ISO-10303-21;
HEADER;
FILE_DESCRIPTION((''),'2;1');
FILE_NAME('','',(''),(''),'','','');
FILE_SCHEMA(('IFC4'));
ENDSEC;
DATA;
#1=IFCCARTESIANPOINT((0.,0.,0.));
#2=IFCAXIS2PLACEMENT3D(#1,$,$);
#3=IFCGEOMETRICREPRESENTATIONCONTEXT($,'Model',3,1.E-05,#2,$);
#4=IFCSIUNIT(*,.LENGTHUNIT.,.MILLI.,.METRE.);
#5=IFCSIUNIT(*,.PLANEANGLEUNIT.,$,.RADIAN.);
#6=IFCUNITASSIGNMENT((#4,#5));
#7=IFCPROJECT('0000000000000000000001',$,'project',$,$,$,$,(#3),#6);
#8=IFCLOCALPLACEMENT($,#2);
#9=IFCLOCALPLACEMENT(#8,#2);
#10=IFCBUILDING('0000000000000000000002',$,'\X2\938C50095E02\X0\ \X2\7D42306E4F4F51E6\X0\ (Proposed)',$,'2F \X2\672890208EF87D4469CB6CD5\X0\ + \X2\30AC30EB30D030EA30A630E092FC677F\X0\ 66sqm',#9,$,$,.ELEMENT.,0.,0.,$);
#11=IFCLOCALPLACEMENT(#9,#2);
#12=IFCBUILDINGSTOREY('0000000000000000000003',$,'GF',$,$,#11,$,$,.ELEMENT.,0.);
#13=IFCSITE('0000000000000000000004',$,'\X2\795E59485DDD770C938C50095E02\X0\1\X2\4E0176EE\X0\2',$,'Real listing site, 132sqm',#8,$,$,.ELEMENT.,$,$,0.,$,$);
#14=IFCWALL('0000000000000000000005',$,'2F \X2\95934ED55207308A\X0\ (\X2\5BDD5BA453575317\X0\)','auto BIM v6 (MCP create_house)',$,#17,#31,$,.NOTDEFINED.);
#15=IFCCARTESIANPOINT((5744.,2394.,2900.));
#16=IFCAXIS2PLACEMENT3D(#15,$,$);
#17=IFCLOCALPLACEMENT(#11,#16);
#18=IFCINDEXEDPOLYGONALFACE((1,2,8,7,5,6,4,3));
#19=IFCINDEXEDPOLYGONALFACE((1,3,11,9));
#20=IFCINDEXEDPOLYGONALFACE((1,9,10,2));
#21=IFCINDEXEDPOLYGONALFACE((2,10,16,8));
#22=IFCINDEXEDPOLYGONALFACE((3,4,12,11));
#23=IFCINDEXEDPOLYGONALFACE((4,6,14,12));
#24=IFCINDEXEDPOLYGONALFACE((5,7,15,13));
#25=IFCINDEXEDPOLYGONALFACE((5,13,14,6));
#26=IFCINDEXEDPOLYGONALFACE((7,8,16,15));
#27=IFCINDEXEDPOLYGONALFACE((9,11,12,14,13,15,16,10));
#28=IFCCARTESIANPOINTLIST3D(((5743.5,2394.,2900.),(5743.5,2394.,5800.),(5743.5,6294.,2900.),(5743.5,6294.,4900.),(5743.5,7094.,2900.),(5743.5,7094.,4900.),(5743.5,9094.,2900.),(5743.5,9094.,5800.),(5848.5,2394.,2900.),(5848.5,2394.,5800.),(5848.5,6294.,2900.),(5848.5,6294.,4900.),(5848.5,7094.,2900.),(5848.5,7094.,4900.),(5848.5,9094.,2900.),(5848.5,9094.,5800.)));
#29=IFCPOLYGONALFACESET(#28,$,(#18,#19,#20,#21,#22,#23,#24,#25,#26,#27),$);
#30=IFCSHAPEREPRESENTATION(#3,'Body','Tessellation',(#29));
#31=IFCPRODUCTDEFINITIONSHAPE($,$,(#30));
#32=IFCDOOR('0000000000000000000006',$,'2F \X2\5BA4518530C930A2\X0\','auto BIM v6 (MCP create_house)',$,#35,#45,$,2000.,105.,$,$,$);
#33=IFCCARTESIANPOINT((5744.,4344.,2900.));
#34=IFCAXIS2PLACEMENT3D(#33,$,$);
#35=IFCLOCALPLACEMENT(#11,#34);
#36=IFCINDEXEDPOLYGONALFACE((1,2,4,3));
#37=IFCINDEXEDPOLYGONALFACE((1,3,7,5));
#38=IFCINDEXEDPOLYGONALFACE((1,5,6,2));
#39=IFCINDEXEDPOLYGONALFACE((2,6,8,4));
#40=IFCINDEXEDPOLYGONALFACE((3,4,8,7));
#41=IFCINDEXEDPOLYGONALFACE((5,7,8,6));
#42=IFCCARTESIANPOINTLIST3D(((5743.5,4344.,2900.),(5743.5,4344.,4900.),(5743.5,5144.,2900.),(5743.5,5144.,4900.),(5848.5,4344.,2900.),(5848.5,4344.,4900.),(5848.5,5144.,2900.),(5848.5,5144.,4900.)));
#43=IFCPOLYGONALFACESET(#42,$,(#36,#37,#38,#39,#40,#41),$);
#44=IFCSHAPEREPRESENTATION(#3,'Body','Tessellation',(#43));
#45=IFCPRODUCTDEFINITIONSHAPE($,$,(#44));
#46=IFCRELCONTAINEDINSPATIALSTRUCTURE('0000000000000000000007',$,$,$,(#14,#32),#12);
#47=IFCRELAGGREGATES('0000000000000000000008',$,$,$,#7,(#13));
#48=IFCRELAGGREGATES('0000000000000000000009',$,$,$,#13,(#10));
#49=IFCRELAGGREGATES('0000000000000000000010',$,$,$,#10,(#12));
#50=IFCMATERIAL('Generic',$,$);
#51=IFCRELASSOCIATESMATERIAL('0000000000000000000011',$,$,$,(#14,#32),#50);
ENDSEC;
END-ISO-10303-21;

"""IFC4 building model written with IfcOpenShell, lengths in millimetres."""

from ifc_helpers import new_model, si_unit, frame, frame_2d, origin, place, context, project, spatial, rectangle, extrude, material, element, fill, save


model = new_model("IFC4")

# Units and contexts
model_context = context("Model", 3, precision=1e-05, world=origin())
ifc_project = project(units=[si_unit("LENGTHUNIT", "METRE", prefix="MILLI"), si_unit("PLANEANGLEUNIT", "RADIAN")], contexts=[model_context])

# Site, building, storey
site_placement = place(None, origin())
site = spatial("IfcSite", under=ifc_project, at=site_placement, Name="神奈川県鎌倉市1丁目2", ObjectType="Real listing site, 132sqm", CompositionType="ELEMENT", RefElevation=0.0)
building_placement = place(site_placement, origin())
building = spatial("IfcBuilding", under=site, at=building_placement, Name="鎌倉市 終の住処 (Proposed)", ObjectType="2F 木造軸組構法 + ガルバリウム鋼板 66sqm", CompositionType="ELEMENT", ElevationOfRefHeight=0.0, ElevationOfTerrain=0.0)
storey_placement = place(building_placement, origin())
storey = spatial("IfcBuildingStorey", under=building, at=storey_placement, Name="GF", CompositionType="ELEMENT", Elevation=0.0)

# Shared definitions
ifc_material = material(Name="Generic")

# Wall, opening, door
wall_1_placement = place(storey_placement, frame((5744.0, 2394.0, 2900.0)))
wall_1 = element("IfcWall", 1, at=wall_1_placement, inside=storey, material=ifc_material, Name="2F 間仕切り (寝室南北)", Description="auto BIM v6 (MCP create_house)", PredefinedType="NOTDEFINED", context=model_context, shape_type="SweptSolid", body=[
    extrude(rectangle(XDim=105.0, YDim=6700.0, at=frame_2d((52.0, 3350.0))), frame((5744.0, 2394.0, 2900.0)), (0.0, 0.0, 1.0), 2900.0),
])
opening_1_placement = place(storey_placement, frame((5744.0, 4344.0, 2900.0)))
opening_1 = element("IfcOpeningElement", 2, at=opening_1_placement, cuts=wall_1, PredefinedType="NOTDEFINED", context=model_context, shape_type="SweptSolid", body=[
    extrude(rectangle(XDim=105.0, YDim=800.0, at=frame_2d((52.0, 400.0))), frame((5744.0, 4344.0, 2900.0)), (0.0, 0.0, 1.0), 2000.0),
])
door_placement = place(storey_placement, frame((5744.0, 4344.0, 2900.0)))
door = element("IfcDoor", 3, at=door_placement, inside=storey, material=ifc_material, Name="2F 室内ドア", Description="auto BIM v6 (MCP create_house)", OverallHeight=2000.0, OverallWidth=105.0, context=model_context, shape_type="SweptSolid", body=[
    extrude(rectangle(XDim=105.0, YDim=800.0, at=frame_2d((52.0, 400.0))), frame((5744.0, 4344.0, 2900.0)), (0.0, 0.0, 1.0), 2000.0),
])
fill(opening_1, door)

save(model, "model.ifc")
